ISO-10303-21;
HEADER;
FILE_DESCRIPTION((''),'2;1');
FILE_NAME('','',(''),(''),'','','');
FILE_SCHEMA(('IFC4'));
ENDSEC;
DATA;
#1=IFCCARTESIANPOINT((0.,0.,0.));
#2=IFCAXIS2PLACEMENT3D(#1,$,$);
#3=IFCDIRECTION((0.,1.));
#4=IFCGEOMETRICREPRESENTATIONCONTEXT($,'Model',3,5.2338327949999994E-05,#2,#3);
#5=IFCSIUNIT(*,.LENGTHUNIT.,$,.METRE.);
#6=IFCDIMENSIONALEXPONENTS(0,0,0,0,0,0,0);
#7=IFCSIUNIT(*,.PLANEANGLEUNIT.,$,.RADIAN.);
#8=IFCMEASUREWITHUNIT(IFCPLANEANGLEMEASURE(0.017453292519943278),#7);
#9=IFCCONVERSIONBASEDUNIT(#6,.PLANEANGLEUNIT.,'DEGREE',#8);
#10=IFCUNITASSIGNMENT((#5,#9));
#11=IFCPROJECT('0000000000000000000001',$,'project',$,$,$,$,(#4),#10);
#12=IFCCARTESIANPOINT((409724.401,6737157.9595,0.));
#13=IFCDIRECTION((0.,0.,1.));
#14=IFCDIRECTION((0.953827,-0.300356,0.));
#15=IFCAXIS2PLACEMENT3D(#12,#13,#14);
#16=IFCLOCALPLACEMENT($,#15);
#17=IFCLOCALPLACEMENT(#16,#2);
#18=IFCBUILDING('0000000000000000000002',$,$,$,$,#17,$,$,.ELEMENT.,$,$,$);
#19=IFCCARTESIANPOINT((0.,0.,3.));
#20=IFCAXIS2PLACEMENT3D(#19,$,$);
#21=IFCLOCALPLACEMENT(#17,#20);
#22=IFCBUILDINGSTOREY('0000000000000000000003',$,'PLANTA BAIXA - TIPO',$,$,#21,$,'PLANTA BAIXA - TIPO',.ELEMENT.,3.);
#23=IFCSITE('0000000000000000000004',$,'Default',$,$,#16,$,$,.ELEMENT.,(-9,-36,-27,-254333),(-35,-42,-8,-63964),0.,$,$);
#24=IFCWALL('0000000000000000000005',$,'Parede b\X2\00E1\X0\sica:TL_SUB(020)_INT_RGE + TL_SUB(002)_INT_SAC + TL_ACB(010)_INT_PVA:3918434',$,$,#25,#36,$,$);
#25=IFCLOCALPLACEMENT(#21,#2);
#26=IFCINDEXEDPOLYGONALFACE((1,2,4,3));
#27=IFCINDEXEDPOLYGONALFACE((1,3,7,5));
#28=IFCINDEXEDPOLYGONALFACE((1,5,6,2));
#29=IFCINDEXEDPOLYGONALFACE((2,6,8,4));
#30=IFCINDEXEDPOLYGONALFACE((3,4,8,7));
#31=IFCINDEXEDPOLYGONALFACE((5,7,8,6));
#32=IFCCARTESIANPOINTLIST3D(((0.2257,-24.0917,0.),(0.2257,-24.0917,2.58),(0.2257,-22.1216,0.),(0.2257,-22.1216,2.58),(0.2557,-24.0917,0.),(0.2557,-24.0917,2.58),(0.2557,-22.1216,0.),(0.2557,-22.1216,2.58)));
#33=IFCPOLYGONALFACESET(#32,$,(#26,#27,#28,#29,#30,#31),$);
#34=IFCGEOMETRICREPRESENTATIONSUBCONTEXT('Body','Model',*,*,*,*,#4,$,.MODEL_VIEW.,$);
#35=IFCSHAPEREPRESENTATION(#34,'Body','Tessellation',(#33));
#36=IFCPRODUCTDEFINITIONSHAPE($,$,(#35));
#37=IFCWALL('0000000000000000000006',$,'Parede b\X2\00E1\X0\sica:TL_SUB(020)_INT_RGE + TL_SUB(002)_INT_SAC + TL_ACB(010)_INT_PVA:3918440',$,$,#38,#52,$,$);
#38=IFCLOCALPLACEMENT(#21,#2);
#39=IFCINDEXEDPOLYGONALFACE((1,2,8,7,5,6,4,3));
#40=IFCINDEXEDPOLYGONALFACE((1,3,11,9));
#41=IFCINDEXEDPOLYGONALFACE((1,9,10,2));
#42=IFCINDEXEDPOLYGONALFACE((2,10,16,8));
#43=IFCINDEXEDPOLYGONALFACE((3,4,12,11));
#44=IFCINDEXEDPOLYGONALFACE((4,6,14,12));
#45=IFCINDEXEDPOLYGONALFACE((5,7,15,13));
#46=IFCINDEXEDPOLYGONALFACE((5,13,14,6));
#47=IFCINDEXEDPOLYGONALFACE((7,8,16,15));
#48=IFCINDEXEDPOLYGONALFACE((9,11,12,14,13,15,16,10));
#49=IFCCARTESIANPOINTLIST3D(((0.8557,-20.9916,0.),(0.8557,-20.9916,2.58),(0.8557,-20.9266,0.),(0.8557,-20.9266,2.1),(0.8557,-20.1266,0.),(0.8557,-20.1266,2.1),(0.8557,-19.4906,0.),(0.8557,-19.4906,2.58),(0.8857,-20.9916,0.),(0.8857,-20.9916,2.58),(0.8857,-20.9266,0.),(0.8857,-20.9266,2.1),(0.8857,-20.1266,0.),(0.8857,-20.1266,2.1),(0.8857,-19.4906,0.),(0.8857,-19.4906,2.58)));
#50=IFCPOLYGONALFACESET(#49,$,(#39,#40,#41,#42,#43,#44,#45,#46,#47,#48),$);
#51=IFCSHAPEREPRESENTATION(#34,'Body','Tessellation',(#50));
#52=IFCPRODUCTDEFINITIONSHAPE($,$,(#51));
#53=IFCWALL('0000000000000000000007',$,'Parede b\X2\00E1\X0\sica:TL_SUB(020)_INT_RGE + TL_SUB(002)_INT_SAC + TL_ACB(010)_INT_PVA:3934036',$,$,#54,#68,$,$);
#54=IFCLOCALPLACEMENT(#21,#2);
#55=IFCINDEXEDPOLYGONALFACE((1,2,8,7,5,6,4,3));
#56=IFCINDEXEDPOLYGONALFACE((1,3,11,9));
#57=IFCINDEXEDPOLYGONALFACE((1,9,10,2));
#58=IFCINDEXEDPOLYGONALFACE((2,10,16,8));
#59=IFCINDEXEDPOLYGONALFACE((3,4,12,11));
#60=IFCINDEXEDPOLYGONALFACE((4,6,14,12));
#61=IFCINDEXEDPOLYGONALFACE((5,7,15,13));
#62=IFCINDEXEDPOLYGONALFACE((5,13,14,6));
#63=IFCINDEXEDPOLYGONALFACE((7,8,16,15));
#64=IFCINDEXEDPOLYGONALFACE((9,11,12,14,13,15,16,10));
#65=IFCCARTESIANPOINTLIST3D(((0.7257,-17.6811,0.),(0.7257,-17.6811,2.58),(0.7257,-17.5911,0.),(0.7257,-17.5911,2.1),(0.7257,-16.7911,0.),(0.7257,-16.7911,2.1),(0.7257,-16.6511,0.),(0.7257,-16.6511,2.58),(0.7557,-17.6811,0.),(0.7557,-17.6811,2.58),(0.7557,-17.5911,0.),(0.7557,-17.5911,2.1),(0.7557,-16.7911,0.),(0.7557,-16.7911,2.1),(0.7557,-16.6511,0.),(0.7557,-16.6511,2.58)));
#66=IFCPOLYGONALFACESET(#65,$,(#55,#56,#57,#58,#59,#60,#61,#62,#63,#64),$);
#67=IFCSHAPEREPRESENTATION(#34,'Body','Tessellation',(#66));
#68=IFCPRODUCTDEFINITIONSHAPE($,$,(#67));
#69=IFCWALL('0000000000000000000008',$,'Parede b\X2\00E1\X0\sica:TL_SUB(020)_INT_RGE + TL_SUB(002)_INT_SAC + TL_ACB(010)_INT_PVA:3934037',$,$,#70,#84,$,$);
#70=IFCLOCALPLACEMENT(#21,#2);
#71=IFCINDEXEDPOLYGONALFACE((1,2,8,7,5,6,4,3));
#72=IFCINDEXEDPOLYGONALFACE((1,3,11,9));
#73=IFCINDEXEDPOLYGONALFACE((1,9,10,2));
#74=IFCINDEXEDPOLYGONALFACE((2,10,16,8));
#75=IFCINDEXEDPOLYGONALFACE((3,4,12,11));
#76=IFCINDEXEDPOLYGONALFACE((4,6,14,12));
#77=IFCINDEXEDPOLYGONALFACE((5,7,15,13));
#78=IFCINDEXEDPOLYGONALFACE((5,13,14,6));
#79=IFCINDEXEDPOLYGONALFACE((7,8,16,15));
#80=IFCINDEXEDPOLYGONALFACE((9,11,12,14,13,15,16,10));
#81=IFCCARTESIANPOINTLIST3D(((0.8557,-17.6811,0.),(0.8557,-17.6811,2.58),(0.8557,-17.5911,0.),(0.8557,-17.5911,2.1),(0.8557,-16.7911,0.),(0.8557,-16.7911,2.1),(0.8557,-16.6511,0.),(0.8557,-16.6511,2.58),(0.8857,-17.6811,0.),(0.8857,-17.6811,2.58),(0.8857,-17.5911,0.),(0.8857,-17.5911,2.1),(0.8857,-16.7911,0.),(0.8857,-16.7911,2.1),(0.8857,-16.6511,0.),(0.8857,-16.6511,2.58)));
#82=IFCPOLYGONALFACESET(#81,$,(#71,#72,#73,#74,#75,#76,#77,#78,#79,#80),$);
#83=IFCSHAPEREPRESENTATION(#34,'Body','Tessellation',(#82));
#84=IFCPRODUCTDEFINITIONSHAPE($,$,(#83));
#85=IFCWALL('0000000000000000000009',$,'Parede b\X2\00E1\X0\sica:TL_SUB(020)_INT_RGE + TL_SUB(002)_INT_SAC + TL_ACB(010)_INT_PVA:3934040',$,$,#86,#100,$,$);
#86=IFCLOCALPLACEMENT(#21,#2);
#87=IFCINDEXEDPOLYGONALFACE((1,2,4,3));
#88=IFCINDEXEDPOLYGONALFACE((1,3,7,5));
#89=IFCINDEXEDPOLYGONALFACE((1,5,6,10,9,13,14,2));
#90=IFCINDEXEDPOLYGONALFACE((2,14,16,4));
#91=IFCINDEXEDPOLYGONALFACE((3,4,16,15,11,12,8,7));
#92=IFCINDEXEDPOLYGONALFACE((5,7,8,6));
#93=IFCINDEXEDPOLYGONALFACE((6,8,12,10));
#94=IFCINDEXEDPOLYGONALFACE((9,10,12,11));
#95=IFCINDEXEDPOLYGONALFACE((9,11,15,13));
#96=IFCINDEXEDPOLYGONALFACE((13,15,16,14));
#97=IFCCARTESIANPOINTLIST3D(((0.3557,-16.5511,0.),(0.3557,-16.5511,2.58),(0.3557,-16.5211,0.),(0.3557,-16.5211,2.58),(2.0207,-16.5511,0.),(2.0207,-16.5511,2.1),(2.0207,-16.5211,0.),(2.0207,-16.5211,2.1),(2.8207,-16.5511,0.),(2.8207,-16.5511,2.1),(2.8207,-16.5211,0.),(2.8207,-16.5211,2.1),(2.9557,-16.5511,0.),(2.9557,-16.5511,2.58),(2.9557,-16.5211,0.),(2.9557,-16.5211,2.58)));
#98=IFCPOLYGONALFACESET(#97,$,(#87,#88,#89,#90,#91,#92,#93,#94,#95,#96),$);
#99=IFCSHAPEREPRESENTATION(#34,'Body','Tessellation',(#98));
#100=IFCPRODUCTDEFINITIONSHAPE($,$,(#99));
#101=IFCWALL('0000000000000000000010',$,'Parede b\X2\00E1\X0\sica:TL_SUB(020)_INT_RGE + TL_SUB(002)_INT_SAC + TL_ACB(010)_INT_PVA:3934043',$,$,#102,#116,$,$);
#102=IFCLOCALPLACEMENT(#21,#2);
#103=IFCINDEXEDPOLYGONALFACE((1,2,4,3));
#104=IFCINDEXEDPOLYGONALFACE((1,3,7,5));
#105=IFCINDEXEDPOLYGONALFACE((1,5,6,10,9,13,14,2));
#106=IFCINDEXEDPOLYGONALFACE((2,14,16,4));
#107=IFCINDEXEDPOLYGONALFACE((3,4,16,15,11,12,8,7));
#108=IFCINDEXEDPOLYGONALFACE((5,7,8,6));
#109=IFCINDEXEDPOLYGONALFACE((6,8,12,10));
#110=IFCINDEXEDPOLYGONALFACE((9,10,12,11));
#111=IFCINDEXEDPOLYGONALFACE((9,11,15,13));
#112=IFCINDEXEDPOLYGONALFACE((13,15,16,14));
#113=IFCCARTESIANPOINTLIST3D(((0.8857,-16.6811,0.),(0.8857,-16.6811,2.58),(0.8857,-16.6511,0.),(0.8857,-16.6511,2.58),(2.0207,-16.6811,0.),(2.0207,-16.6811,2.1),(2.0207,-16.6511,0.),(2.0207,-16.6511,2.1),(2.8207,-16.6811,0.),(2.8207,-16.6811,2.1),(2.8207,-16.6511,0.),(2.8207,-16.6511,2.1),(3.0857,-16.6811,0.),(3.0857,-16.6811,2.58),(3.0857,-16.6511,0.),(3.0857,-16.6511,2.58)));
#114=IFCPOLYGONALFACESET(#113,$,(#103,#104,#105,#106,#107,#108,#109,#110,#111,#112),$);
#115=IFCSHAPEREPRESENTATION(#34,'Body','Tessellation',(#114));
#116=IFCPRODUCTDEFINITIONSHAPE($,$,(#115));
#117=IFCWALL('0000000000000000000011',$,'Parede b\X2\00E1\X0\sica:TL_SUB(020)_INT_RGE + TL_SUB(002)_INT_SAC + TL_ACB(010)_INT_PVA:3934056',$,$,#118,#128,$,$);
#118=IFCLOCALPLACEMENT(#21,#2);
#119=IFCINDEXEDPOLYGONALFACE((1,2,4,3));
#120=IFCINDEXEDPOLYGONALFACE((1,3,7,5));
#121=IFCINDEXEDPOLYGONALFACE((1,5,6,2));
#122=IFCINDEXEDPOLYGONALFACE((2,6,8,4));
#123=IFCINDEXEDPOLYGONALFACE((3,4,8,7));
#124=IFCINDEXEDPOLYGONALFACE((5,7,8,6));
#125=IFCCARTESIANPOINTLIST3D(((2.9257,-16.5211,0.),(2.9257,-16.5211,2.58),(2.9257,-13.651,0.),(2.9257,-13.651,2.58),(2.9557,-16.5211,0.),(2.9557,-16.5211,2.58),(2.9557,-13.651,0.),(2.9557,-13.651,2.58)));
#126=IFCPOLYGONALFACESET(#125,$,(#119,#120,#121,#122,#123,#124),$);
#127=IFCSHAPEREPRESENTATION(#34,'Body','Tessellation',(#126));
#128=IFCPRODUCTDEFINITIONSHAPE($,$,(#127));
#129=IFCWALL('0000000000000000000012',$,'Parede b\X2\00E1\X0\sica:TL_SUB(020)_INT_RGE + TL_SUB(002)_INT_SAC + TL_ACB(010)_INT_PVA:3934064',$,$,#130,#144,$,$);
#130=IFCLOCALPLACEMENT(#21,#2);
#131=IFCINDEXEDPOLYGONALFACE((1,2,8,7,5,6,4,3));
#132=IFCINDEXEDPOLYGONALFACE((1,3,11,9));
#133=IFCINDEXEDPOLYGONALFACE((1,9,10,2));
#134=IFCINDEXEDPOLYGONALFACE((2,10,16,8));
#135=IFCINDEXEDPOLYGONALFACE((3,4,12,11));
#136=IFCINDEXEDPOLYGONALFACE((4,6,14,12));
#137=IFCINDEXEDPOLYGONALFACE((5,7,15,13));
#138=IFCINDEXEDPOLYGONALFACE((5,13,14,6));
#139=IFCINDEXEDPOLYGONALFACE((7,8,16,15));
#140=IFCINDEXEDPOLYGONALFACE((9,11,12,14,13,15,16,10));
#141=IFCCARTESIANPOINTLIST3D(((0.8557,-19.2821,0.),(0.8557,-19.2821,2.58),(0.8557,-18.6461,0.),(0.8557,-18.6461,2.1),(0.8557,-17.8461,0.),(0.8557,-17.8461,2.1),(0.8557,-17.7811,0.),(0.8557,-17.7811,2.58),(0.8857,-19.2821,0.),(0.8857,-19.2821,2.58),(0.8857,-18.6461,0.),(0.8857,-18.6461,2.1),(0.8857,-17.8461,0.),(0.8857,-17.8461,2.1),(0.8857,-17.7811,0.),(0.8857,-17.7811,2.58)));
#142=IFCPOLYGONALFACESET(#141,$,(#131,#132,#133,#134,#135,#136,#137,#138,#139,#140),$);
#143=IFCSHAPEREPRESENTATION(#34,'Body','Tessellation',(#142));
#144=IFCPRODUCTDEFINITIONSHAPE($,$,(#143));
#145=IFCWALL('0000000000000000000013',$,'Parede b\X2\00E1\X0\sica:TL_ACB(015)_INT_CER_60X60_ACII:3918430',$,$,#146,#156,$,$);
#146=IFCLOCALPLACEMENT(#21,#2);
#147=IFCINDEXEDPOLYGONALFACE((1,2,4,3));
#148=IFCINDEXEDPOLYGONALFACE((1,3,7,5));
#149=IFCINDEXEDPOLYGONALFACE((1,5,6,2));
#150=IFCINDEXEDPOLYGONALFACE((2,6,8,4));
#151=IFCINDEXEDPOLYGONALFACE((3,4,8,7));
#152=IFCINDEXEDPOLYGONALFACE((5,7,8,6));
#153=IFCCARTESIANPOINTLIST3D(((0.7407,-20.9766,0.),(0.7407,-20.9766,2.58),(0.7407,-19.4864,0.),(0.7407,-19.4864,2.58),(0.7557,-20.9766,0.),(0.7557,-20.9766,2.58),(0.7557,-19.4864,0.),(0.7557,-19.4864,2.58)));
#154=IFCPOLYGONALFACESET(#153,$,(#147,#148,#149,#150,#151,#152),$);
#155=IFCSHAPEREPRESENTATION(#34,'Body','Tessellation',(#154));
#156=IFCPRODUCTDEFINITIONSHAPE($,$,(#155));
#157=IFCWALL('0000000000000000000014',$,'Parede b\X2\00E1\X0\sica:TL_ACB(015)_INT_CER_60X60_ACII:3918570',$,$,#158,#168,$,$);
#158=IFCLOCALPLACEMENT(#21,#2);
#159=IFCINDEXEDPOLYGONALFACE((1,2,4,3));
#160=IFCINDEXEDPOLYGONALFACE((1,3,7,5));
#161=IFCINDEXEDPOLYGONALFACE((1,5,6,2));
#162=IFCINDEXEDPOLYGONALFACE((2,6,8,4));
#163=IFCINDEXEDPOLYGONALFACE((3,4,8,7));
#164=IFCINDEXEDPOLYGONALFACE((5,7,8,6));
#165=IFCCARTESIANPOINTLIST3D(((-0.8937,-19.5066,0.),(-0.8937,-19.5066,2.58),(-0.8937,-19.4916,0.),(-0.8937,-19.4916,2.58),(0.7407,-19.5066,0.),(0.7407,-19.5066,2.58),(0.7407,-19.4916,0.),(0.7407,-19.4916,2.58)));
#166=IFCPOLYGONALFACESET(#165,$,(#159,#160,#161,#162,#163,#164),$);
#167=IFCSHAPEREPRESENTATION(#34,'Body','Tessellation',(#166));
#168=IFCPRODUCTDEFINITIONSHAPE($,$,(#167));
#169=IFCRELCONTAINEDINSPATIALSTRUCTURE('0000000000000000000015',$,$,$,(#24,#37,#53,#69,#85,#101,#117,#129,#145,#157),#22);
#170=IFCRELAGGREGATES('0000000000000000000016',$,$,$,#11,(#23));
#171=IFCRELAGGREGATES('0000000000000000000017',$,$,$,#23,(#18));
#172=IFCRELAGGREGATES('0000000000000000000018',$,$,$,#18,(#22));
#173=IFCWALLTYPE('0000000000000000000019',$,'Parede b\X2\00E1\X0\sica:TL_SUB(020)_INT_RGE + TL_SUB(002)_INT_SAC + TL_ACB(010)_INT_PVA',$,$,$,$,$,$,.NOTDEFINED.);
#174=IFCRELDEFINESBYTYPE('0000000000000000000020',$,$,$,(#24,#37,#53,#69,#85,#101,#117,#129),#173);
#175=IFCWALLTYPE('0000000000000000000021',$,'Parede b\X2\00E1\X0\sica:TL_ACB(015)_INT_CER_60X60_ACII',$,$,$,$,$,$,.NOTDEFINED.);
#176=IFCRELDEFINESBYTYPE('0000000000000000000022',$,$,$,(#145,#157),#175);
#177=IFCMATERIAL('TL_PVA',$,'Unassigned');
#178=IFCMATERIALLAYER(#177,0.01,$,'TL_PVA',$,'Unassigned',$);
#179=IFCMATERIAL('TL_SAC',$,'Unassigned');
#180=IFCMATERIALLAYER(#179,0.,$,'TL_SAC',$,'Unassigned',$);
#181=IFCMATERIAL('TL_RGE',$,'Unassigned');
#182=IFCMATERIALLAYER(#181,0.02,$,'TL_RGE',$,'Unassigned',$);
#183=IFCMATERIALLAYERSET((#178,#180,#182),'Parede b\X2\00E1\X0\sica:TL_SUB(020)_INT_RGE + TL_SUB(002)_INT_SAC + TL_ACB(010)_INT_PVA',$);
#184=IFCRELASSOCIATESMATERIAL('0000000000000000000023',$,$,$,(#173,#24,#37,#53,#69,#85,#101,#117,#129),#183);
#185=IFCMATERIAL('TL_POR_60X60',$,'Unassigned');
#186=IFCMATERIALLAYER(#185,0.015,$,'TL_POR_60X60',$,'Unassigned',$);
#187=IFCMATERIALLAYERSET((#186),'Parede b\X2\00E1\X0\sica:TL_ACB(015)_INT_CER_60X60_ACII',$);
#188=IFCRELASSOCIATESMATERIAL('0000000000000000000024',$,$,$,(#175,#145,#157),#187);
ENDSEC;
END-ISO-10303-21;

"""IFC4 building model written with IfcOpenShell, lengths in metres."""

from ifc_helpers import new_model, entity, si_unit, converted_unit, direction, frame, frame_2d, origin, place, context, subcontext, project, spatial, rectangle, extrude, material, layer, layer_set, layer_usage, type_object, element, save


model = new_model("IFC4")

# Units and contexts
model_context = context("Model", 3, precision=5.2338327949999994e-05, world=origin(), true_north=direction((0.0, 1.0)))
body_context = subcontext(model_context, "Body", "Model", "MODEL_VIEW")
ifc_project = project(units=[si_unit("LENGTHUNIT", "METRE"), converted_unit("PLANEANGLEUNIT", "DEGREE", entity("IfcPlaneAngleMeasure", 0.017453292519943278), si_unit("PLANEANGLEUNIT", "RADIAN"), dimensions=[0, 0, 0, 0, 0, 0, 0])], contexts=[model_context])

# Site, building, storey
site_placement = place(None, frame((409724.401, 6737157.9595, 0.0), z_axis=(0.0, 0.0, 1.0), x_axis=(0.953827, -0.300356, 0.0)))
site = spatial("IfcSite", under=ifc_project, at=site_placement, Name="Default", CompositionType="ELEMENT", RefLatitude=(-9, -36, -27, -254333), RefLongitude=(-35, -42, -8, -63964), RefElevation=0.0)
building_placement = place(site_placement, origin())
building = spatial("IfcBuilding", under=site, at=building_placement, CompositionType="ELEMENT")
storey_placement = place(building_placement, frame((0.0, 0.0, 3.0)))
storey = spatial("IfcBuildingStorey", under=building, at=storey_placement, Name="PLANTA BAIXA - TIPO", LongName="PLANTA BAIXA - TIPO", CompositionType="ELEMENT", Elevation=3.0)

# Shared definitions
ifc_material_1 = material(Name="TL_PVA", Category="Unassigned")
ifc_layer_1 = layer(ifc_material_1, 0.01, Name="TL_PVA", Category="Unassigned")
ifc_material_2 = material(Name="TL_SAC", Category="Unassigned")
ifc_layer_2 = layer(ifc_material_2, 0.0, Name="TL_SAC", Category="Unassigned")
ifc_material_3 = material(Name="TL_RGE", Category="Unassigned")
ifc_layer_3 = layer(ifc_material_3, 0.02, Name="TL_RGE", Category="Unassigned")
ifc_layer_set_1 = layer_set([ifc_layer_1, ifc_layer_2, ifc_layer_3], Name="Parede básica:TL_SUB(020)_INT_RGE + TL_SUB(002)_INT_SAC + TL_ACB(010)_INT_PVA")
wall_type_1 = type_object("IfcWallType", Name="Parede básica:TL_SUB(020)_INT_RGE + TL_SUB(002)_INT_SAC + TL_ACB(010)_INT_PVA", PredefinedType="NOTDEFINED", material=ifc_layer_set_1)

# Wall
ifc_layer_usage_1 = layer_usage(ifc_layer_set_1, "AXIS2", "POSITIVE", -0.015)
wall_1_placement = place(storey_placement, frame((0.2407, -22.1216, 0.0), z_axis=(0.0, 0.0, 1.0), x_axis=(0.0, -1.0, 0.0)))
element("IfcWall", 1, at=wall_1_placement, inside=storey, type_object=wall_type_1, material=ifc_layer_usage_1, Name="Parede básica:TL_SUB(020)_INT_RGE + TL_SUB(002)_INT_SAC + TL_ACB(010)_INT_PVA:3918434", context=body_context, shape_type="SweptSolid", body=[
    extrude(rectangle(XDim=1.9701, YDim=0.03, at=frame_2d((0.9851, 0.0), x_axis=(-1.0, 0.0))), origin(), (0.0, 0.0, 1.0), 2.58),
])

# Walls, openings
ifc_layer_usage_2 = layer_usage(ifc_layer_set_1, "AXIS2", "POSITIVE", -0.015)
wall_2_placement = place(storey_placement, frame((0.8707, -20.9916, 0.0), z_axis=(0.0, 0.0, 1.0), x_axis=(0.0, 1.0, 0.0)))
wall_2 = element("IfcWall", 2, at=wall_2_placement, inside=storey, type_object=wall_type_1, material=ifc_layer_usage_2, Name="Parede básica:TL_SUB(020)_INT_RGE + TL_SUB(002)_INT_SAC + TL_ACB(010)_INT_PVA:3918440", context=body_context, shape_type="SweptSolid", body=[
    extrude(rectangle(XDim=1.501, YDim=0.03, at=frame_2d((0.7505, 0.0), x_axis=(-1.0, 0.0))), origin(), (0.0, 0.0, 1.0), 2.58),
])
opening_1_placement = place(wall_2_placement, frame((0.065, -0.015, 0.0)))
element("IfcOpeningElement", 3, at=opening_1_placement, cuts=wall_2, PredefinedType="OPENING", context=body_context, shape_type="SweptSolid", body=[
    extrude(rectangle(XDim=2.1, YDim=0.8, at=frame_2d((1.05, 0.4), x_axis=(1.0, 0.0))), frame((0.0, 0.0, 0.0), z_axis=(0.0, 1.0, 0.0), x_axis=(0.0, 0.0, 1.0)), (0.0, 0.0, 1.0), 0.03),
])
ifc_layer_usage_3 = layer_usage(ifc_layer_set_1, "AXIS2", "POSITIVE", -0.015)
wall_3_placement = place(storey_placement, frame((0.7407, -16.6511, 0.0), z_axis=(0.0, 0.0, 1.0), x_axis=(0.0, -1.0, 0.0)))
wall_3 = element("IfcWall", 4, at=wall_3_placement, inside=storey, type_object=wall_type_1, material=ifc_layer_usage_3, Name="Parede básica:TL_SUB(020)_INT_RGE + TL_SUB(002)_INT_SAC + TL_ACB(010)_INT_PVA:3934036", context=body_context, shape_type="SweptSolid", body=[
    extrude(rectangle(XDim=1.03, YDim=0.03, at=frame_2d((0.515, 0.0), x_axis=(1.0, 0.0))), origin(), (0.0, 0.0, 1.0), 2.58),
])
opening_2_placement = place(wall_3_placement, frame((-16.6511, -0.7407, 0.0)))
element("IfcOpeningElement", 5, at=opening_2_placement, cuts=wall_3, PredefinedType="OPENING", context=body_context, shape_type="SweptSolid", body=[
    extrude(rectangle(XDim=2.1, YDim=0.8, at=frame_2d((0.0, 0.0), x_axis=(0.0, 1.0))), frame((17.1911, -0.6683, 1.05), z_axis=(0.0, 1.0, 0.0), x_axis=(-1.0, 0.0, 0.0)), (0.0, 0.0, 1.0), 3.048),
])
ifc_layer_usage_4 = layer_usage(ifc_layer_set_1, "AXIS2", "POSITIVE", -0.015)
wall_4_placement = place(storey_placement, frame((0.8707, -17.6811, 0.0), z_axis=(0.0, 0.0, 1.0), x_axis=(0.0, 1.0, 0.0)))
wall_4 = element("IfcWall", 6, at=wall_4_placement, inside=storey, type_object=wall_type_1, material=ifc_layer_usage_4, Name="Parede básica:TL_SUB(020)_INT_RGE + TL_SUB(002)_INT_SAC + TL_ACB(010)_INT_PVA:3934037", context=body_context, shape_type="SweptSolid", body=[
    extrude(rectangle(XDim=1.03, YDim=0.03, at=frame_2d((0.515, 0.0), x_axis=(1.0, 0.0))), origin(), (0.0, 0.0, 1.0), 2.58),
])
opening_3_placement = place(wall_4_placement, frame((17.6811, 0.8707, 0.0)))
element("IfcOpeningElement", 7, at=opening_3_placement, cuts=wall_4, PredefinedType="OPENING", context=body_context, shape_type="SweptSolid", body=[
    extrude(rectangle(XDim=2.1, YDim=0.8, at=frame_2d((0.0, 0.0), x_axis=(1.0, 0.0))), frame((-17.1911, -2.3797, 1.05), z_axis=(0.0, 1.0, 0.0), x_axis=(0.0, 0.0, 1.0)), (0.0, 0.0, 1.0), 3.048),
])
ifc_layer_usage_5 = layer_usage(ifc_layer_set_1, "AXIS2", "POSITIVE", -0.015)
wall_5_placement = place(storey_placement, frame((2.9557, -16.5361, 0.0), z_axis=(0.0, 0.0, 1.0), x_axis=(-1.0, 0.0, 0.0)))
wall_5 = element("IfcWall", 8, at=wall_5_placement, inside=storey, type_object=wall_type_1, material=ifc_layer_usage_5, Name="Parede básica:TL_SUB(020)_INT_RGE + TL_SUB(002)_INT_SAC + TL_ACB(010)_INT_PVA:3934040", context=body_context, shape_type="SweptSolid", body=[
    extrude(rectangle(XDim=2.6, YDim=0.03, at=frame_2d((1.3, 0.0), x_axis=(-1.0, 0.0))), origin(), (0.0, 0.0, 1.0), 2.58),
])
opening_4_placement = place(wall_5_placement, frame((2.9557, -16.5361, 0.0)))
element("IfcOpeningElement", 9, at=opening_4_placement, cuts=wall_5, PredefinedType="OPENING", context=body_context, shape_type="SweptSolid", body=[
    extrude(rectangle(XDim=2.1, YDim=0.8, at=frame_2d((0.0, 0.0), x_axis=(1.0, 0.0))), frame((-2.4207, 15.1271, 1.05), z_axis=(0.0, 1.0, 0.0), x_axis=(0.0, 0.0, 1.0)), (0.0, 0.0, 1.0), 3.048),
])
ifc_layer_usage_6 = layer_usage(ifc_layer_set_1, "AXIS2", "POSITIVE", -0.015)
wall_6_placement = place(storey_placement, frame((0.8857, -16.6661, 0.0)))
wall_6 = element("IfcWall", 10, at=wall_6_placement, inside=storey, type_object=wall_type_1, material=ifc_layer_usage_6, Name="Parede básica:TL_SUB(020)_INT_RGE + TL_SUB(002)_INT_SAC + TL_ACB(010)_INT_PVA:3934043", context=body_context, shape_type="SweptSolid", body=[
    extrude(rectangle(XDim=2.2, YDim=0.03, at=frame_2d((1.1, 0.0), x_axis=(-1.0, 0.0))), origin(), (0.0, 0.0, 1.0), 2.58),
])
opening_5_placement = place(wall_6_placement, frame((-0.8857, 16.6661, 0.0)))
element("IfcOpeningElement", 11, at=opening_5_placement, cuts=wall_6, PredefinedType="OPENING", context=body_context, shape_type="SweptSolid", body=[
    extrude(rectangle(XDim=2.1, YDim=0.8, at=frame_2d((0.0, 0.0), x_axis=(0.0, 1.0))), frame((2.4207, -18.1751, 1.05), z_axis=(0.0, 1.0, 0.0), x_axis=(-1.0, 0.0, 0.0)), (0.0, 0.0, 1.0), 3.048),
])

# Wall
ifc_layer_usage_7 = layer_usage(ifc_layer_set_1, "AXIS2", "NEGATIVE", 0.015)
wall_7_placement = place(storey_placement, frame((2.9407, -16.5211, 0.0), z_axis=(0.0, 0.0, 1.0), x_axis=(0.0, 1.0, 0.0)))
element("IfcWall", 12, at=wall_7_placement, inside=storey, type_object=wall_type_1, material=ifc_layer_usage_7, Name="Parede básica:TL_SUB(020)_INT_RGE + TL_SUB(002)_INT_SAC + TL_ACB(010)_INT_PVA:3934056", context=body_context, shape_type="SweptSolid", body=[
    extrude(rectangle(XDim=2.8701, YDim=0.03, at=frame_2d((1.4351, 0.0), x_axis=(-1.0, 0.0))), origin(), (0.0, 0.0, 1.0), 2.58),
])

# Wall, opening
ifc_layer_usage_8 = layer_usage(ifc_layer_set_1, "AXIS2", "NEGATIVE", 0.015)
wall_8_placement = place(storey_placement, frame((0.8707, -17.7811, 0.0), z_axis=(0.0, 0.0, 1.0), x_axis=(0.0, -1.0, 0.0)))
wall_8 = element("IfcWall", 13, at=wall_8_placement, inside=storey, type_object=wall_type_1, material=ifc_layer_usage_8, Name="Parede básica:TL_SUB(020)_INT_RGE + TL_SUB(002)_INT_SAC + TL_ACB(010)_INT_PVA:3934064", context=body_context, shape_type="SweptSolid", body=[
    extrude(rectangle(XDim=1.501, YDim=0.03, at=frame_2d((0.7505, 0.0), x_axis=(-1.0, 0.0))), origin(), (0.0, 0.0, 1.0), 2.58),
])
opening_6_placement = place(wall_8_placement, frame((0.865, 0.015, 0.0)))
element("IfcOpeningElement", 14, at=opening_6_placement, cuts=wall_8, PredefinedType="OPENING", context=body_context, shape_type="SweptSolid", body=[
    extrude(rectangle(XDim=2.1, YDim=0.8, at=frame_2d((1.05, 0.4), x_axis=(1.0, 0.0))), frame((0.0, 0.0, 0.0), z_axis=(0.0, -1.0, 0.0), x_axis=(0.0, 0.0, 1.0)), (0.0, 0.0, 1.0), 0.03),
])

# Walls
ifc_material_4 = material(Name="TL_POR_60X60", Category="Unassigned")
ifc_layer_4 = layer(ifc_material_4, 0.015, Name="TL_POR_60X60", Category="Unassigned")
ifc_layer_set_2 = layer_set([ifc_layer_4], Name="Parede básica:TL_ACB(015)_INT_CER_60X60_ACII")
ifc_layer_usage_9 = layer_usage(ifc_layer_set_2, "AXIS2", "POSITIVE", -0.0075)
wall_type_2 = type_object("IfcWallType", Name="Parede básica:TL_ACB(015)_INT_CER_60X60_ACII", PredefinedType="NOTDEFINED", material=ifc_layer_set_2)
wall_9_placement = place(storey_placement, frame((0.7482, -19.4864, 0.0), z_axis=(0.0, 0.0, 1.0), x_axis=(0.0, -1.0, 0.0)))
element("IfcWall", 15, at=wall_9_placement, inside=storey, type_object=wall_type_2, material=ifc_layer_usage_9, Name="Parede básica:TL_ACB(015)_INT_CER_60X60_ACII:3918430", context=body_context, shape_type="SweptSolid", body=[
    extrude(rectangle(XDim=1.4902, YDim=0.015, at=frame_2d((0.7451, 0.0), x_axis=(-1.0, 0.0))), origin(), (0.0, 0.0, 1.0), 2.58),
])
ifc_layer_usage_10 = layer_usage(ifc_layer_set_2, "AXIS2", "NEGATIVE", 0.0075)
wall_10_placement = place(storey_placement, frame((0.7407, -19.4991, 0.0), z_axis=(0.0, 0.0, 1.0), x_axis=(-1.0, 0.0, 0.0)))
element("IfcWall", 16, at=wall_10_placement, inside=storey, type_object=wall_type_2, material=ifc_layer_usage_10, Name="Parede básica:TL_ACB(015)_INT_CER_60X60_ACII:3918570", context=body_context, shape_type="SweptSolid", body=[
    extrude(rectangle(XDim=1.6345, YDim=0.015, at=frame_2d((0.8172, 0.0), x_axis=(-1.0, 0.0))), origin(), (0.0, 0.0, 1.0), 2.58),
])

save(model, "model.ifc")
